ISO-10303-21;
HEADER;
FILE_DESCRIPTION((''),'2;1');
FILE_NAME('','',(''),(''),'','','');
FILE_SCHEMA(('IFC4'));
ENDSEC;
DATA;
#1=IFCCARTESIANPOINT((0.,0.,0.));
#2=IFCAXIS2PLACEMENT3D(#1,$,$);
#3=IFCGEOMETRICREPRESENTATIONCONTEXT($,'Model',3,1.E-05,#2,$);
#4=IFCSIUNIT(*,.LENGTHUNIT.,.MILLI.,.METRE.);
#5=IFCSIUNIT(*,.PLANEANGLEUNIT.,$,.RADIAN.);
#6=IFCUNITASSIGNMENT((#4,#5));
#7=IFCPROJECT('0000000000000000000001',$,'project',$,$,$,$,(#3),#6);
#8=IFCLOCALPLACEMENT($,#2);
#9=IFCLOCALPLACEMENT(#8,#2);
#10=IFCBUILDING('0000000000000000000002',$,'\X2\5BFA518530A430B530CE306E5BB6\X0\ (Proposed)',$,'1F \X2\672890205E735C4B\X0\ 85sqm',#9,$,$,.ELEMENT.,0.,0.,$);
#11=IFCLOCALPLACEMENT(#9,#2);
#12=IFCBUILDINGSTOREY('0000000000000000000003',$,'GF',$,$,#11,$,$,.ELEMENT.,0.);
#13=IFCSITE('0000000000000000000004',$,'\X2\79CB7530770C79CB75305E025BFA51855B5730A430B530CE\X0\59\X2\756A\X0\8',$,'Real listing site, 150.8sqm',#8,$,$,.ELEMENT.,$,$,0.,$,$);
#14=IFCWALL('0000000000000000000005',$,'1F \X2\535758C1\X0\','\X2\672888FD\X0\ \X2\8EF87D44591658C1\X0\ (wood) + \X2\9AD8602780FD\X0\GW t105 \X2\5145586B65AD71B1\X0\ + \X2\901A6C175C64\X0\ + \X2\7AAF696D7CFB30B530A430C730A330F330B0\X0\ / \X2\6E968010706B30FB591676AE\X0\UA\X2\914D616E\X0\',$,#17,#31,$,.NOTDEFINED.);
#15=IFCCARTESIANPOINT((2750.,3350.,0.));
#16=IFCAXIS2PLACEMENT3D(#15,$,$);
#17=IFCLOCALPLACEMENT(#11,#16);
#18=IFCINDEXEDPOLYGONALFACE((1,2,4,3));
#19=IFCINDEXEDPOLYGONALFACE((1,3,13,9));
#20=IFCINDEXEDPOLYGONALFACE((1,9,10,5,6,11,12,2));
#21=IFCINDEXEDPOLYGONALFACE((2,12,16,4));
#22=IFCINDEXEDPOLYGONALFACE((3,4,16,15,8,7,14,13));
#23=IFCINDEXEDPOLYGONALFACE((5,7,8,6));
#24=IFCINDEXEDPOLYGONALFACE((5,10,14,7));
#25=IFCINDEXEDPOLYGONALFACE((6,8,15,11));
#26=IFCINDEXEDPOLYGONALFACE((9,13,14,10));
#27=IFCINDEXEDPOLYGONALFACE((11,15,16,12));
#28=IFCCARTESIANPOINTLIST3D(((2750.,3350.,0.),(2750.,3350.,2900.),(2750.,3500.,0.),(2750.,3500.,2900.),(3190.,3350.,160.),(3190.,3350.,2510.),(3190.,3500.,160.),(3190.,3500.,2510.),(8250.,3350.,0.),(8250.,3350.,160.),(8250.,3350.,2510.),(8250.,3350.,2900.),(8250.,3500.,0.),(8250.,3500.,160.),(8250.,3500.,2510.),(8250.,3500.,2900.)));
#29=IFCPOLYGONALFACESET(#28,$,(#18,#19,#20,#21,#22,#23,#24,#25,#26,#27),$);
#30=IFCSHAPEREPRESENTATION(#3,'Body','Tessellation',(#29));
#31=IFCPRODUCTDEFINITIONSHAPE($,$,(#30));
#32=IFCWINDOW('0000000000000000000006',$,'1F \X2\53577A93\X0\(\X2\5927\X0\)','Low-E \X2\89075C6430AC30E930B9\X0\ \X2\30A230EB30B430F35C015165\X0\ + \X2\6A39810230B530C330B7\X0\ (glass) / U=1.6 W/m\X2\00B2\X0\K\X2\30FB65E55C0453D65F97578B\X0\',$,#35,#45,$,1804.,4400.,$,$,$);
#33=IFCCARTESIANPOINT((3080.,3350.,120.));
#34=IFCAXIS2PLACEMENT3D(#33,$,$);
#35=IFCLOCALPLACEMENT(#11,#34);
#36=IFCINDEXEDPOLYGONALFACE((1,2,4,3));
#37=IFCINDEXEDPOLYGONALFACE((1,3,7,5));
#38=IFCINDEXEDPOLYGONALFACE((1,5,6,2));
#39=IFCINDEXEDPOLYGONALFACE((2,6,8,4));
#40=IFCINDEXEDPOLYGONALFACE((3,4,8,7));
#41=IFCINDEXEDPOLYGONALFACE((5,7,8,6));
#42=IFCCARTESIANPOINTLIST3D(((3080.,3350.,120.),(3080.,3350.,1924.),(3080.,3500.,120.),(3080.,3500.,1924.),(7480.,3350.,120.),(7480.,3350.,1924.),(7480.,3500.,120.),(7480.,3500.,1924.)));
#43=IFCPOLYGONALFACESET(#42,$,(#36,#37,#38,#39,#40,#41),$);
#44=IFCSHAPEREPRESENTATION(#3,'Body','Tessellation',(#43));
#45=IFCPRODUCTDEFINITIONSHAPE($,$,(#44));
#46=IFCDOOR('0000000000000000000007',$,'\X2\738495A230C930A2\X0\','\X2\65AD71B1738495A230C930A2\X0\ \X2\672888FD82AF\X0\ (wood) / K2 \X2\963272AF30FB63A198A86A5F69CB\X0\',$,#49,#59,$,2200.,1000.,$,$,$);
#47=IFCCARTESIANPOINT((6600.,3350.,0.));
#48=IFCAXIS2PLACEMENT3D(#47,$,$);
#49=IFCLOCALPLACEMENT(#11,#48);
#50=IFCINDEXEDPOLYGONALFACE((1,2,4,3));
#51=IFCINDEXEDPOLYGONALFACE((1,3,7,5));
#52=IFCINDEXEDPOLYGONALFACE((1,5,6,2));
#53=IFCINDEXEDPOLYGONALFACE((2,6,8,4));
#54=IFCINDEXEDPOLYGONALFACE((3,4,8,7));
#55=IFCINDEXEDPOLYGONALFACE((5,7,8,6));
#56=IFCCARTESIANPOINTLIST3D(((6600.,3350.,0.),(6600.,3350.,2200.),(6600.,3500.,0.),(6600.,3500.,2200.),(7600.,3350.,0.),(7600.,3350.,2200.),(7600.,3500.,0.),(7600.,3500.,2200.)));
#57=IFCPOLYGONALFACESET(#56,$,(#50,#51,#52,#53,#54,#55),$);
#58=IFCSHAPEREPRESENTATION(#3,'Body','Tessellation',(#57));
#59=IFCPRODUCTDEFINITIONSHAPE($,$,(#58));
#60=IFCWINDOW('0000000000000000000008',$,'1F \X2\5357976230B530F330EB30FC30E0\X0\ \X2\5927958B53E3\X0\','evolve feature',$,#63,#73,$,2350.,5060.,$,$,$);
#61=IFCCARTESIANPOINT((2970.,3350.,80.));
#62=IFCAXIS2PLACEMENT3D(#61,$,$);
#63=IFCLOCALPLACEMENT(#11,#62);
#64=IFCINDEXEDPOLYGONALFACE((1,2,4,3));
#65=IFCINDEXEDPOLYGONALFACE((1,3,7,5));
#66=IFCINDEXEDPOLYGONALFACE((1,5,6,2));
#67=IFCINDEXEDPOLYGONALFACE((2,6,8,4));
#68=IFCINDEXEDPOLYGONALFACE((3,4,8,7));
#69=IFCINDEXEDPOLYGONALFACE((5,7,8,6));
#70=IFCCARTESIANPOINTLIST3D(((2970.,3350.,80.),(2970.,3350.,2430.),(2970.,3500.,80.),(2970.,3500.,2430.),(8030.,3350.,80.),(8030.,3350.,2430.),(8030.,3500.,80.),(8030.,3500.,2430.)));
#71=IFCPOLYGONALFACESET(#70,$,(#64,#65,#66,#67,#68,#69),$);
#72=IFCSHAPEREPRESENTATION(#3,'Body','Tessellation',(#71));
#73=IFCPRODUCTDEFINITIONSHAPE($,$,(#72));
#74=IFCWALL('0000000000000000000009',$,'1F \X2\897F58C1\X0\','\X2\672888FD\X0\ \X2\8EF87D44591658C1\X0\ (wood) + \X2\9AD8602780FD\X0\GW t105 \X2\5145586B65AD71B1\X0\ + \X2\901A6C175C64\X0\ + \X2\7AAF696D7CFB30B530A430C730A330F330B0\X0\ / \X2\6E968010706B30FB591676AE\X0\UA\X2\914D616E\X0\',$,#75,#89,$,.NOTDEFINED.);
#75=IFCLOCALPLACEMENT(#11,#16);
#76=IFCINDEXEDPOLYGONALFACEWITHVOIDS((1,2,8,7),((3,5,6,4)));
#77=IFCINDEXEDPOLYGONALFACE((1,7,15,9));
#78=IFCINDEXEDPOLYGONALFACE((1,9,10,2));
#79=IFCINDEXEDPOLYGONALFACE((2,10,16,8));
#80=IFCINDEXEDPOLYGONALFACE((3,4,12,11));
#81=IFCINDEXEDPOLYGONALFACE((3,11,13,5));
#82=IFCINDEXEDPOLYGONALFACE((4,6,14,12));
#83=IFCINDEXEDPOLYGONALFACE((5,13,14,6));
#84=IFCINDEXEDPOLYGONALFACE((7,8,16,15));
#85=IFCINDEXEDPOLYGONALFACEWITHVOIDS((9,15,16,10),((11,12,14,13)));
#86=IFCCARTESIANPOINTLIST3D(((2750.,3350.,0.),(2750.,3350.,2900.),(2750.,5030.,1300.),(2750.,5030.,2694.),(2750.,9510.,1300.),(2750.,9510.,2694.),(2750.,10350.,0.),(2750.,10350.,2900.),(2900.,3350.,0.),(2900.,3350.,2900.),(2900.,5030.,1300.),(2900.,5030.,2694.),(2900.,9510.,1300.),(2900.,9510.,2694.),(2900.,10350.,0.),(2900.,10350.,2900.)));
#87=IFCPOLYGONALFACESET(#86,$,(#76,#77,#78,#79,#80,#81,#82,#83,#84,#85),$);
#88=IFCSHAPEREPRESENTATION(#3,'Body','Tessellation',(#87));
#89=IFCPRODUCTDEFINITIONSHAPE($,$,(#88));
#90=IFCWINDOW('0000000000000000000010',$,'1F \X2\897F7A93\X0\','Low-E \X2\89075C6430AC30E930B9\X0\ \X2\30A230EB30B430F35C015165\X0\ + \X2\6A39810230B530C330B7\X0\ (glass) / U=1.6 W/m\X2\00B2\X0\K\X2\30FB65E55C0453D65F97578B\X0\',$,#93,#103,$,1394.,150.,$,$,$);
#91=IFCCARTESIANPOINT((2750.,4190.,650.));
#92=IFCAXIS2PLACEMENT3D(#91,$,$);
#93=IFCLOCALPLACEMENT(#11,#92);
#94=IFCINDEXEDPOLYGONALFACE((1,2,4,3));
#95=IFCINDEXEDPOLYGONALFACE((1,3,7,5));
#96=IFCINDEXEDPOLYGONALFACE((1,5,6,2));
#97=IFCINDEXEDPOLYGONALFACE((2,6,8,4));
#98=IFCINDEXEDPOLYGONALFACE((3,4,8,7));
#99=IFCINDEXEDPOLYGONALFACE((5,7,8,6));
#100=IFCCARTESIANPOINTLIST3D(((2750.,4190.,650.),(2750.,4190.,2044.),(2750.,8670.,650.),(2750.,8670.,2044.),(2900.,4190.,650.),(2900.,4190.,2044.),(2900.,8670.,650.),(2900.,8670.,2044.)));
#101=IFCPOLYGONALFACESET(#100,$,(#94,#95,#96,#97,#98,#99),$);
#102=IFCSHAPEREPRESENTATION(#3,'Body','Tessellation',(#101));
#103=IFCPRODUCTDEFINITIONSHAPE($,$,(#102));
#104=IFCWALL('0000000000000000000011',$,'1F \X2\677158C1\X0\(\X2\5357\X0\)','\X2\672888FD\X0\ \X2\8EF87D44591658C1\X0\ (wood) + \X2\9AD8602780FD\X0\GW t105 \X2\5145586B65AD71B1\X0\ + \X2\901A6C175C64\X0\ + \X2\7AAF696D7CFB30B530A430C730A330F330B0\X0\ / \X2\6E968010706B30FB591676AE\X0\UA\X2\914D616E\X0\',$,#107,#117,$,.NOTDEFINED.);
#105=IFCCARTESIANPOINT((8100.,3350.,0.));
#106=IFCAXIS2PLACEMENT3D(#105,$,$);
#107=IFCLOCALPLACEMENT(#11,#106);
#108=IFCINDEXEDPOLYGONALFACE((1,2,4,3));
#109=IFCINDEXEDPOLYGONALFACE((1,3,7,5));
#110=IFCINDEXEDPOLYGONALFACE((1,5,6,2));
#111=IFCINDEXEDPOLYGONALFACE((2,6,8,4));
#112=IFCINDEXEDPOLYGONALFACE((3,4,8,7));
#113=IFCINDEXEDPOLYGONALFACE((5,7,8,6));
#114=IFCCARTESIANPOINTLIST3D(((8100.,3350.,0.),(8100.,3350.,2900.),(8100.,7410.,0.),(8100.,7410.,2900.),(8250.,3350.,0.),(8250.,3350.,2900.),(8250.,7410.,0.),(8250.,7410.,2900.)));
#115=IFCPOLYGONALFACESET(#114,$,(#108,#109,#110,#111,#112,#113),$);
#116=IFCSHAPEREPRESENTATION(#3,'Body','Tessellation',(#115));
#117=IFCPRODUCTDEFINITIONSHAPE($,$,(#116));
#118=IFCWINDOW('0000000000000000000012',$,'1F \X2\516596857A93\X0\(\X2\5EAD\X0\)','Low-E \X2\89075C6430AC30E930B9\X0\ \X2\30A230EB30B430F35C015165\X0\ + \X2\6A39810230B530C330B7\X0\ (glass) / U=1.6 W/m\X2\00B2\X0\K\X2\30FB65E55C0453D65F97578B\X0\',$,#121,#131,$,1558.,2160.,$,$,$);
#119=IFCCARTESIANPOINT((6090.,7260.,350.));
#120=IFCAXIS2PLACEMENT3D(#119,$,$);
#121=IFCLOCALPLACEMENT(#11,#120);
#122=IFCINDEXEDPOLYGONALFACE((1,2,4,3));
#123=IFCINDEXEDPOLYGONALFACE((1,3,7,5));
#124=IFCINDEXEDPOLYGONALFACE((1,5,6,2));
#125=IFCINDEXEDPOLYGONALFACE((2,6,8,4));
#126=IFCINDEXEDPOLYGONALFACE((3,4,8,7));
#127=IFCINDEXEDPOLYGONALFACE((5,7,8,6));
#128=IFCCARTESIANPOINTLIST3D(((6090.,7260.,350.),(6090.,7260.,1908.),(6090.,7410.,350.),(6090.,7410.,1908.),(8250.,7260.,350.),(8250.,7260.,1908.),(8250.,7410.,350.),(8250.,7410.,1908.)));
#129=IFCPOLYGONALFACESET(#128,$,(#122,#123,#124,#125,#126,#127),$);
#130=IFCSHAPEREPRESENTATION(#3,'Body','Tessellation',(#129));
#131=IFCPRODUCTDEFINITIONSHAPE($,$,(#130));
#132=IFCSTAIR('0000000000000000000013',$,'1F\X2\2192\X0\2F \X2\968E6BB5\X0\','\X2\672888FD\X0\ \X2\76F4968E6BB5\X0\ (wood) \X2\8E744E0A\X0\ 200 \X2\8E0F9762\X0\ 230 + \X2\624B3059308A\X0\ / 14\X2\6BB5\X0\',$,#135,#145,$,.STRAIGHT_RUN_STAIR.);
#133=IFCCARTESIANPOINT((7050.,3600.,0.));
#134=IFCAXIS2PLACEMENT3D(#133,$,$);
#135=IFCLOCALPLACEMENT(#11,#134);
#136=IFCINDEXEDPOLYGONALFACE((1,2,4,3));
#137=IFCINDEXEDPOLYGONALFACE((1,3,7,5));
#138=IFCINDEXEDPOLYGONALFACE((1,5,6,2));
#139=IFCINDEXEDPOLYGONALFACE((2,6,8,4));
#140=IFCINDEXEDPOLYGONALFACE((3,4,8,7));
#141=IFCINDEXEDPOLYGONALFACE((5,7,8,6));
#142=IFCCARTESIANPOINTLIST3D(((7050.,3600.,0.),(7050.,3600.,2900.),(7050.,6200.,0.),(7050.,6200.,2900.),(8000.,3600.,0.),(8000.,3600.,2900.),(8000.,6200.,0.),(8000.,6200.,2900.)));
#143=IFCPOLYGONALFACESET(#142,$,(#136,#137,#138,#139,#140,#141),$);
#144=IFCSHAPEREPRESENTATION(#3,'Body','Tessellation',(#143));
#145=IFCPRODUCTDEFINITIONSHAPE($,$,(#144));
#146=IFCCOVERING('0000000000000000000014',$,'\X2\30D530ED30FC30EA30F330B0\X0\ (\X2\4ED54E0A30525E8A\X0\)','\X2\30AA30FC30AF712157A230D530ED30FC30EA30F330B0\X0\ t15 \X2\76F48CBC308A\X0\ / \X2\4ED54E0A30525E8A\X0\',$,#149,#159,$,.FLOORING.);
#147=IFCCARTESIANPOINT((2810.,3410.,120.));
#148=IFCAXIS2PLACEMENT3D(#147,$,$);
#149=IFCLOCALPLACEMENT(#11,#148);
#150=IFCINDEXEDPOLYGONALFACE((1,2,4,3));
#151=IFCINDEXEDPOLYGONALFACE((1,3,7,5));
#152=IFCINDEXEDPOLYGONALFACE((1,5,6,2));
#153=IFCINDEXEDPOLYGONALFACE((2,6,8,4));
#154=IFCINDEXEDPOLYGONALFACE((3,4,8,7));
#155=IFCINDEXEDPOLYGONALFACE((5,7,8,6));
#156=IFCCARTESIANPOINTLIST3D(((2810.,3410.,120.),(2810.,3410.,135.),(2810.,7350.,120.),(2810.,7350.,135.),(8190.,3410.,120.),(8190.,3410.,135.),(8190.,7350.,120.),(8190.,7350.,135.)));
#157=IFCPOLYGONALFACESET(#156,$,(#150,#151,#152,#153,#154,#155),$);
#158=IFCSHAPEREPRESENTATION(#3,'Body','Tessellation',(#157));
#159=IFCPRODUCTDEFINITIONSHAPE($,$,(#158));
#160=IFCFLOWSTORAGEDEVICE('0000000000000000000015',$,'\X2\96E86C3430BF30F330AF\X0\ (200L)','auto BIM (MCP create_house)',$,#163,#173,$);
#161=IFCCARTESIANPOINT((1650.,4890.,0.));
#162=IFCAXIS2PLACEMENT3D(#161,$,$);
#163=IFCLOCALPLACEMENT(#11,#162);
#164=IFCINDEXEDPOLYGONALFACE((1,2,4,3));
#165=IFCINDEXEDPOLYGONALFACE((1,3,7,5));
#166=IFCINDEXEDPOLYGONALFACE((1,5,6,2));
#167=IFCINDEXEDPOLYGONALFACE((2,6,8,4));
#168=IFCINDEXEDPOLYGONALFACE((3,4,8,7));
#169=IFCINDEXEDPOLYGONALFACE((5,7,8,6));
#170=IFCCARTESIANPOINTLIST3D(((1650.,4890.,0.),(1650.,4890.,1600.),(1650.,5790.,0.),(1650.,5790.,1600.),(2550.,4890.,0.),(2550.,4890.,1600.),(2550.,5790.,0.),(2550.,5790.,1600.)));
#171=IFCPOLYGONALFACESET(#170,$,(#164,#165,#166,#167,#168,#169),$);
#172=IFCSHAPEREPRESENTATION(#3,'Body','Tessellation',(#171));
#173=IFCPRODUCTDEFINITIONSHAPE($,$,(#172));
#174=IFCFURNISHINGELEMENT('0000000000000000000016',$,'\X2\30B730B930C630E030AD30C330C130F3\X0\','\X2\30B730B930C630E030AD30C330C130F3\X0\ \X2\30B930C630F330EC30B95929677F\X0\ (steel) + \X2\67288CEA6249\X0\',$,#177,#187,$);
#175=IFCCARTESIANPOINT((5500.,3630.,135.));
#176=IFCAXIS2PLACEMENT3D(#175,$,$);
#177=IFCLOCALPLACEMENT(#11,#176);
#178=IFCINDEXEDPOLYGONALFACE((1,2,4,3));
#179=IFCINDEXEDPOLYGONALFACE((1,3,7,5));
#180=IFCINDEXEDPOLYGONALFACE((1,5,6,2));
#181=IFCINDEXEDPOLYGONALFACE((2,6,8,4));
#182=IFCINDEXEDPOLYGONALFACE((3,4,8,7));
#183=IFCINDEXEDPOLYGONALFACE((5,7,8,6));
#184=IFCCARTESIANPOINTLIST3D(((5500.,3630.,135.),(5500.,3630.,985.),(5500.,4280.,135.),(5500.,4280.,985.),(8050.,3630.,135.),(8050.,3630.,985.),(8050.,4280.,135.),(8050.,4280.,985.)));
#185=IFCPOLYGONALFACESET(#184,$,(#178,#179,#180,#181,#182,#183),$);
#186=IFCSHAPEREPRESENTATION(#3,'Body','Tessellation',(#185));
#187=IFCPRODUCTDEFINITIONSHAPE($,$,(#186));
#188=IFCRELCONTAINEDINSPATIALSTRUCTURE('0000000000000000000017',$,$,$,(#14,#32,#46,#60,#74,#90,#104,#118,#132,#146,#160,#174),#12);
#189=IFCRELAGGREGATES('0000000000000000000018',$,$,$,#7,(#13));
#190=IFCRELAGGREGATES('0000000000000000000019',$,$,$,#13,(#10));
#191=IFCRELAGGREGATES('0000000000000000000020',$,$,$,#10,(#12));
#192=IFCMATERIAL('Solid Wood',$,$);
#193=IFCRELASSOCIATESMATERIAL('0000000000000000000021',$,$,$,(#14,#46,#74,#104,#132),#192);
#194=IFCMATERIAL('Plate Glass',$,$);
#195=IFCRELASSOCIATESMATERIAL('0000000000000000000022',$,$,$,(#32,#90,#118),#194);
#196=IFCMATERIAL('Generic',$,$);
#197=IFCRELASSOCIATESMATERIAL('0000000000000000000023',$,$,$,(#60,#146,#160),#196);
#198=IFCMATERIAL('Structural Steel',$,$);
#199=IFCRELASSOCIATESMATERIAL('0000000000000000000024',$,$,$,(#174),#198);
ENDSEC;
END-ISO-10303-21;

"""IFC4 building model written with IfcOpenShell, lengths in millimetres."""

from ifc_helpers import new_model, si_unit, frame, frame_2d, origin, place, context, project, spatial, rectangle, extrude, material, element, fill, save


model = new_model("IFC4")

# Units and contexts
model_context = context("Model", 3, precision=1e-05, world=origin())
ifc_project = project(units=[si_unit("LENGTHUNIT", "METRE", prefix="MILLI"), si_unit("PLANEANGLEUNIT", "RADIAN")], contexts=[model_context])

# Site, building, storey
site_placement = place(None, origin())
site = spatial("IfcSite", under=ifc_project, at=site_placement, Name="秋田県秋田市寺内字イサノ59番8", ObjectType="Real listing site, 150.8sqm", CompositionType="ELEMENT", RefElevation=0.0)
building_placement = place(site_placement, origin())
building = spatial("IfcBuilding", under=site, at=building_placement, Name="寺内イサノの家 (Proposed)", ObjectType="1F 木造平屋 85sqm", CompositionType="ELEMENT", ElevationOfRefHeight=0.0, ElevationOfTerrain=0.0)
storey_placement = place(building_placement, origin())
storey = spatial("IfcBuildingStorey", under=building, at=storey_placement, Name="GF", CompositionType="ELEMENT", Elevation=0.0)

# Shared definitions
ifc_material_1 = material(Name="Solid Wood")
ifc_material_2 = material(Name="Generic")

# Wall, openings, windows, door
wall_1_placement = place(storey_placement, frame((2750.0, 3350.0, 0.0)))
wall_1 = element("IfcWall", 1, at=wall_1_placement, inside=storey, material=ifc_material_1, Name="1F 南壁", Description="木製 軸組外壁 (wood) + 高性能GW t105 充填断熱 + 通気層 + 窯業系サイディング / 準耐火・外皮UA配慮", PredefinedType="NOTDEFINED", context=model_context, shape_type="SweptSolid", body=[
    extrude(rectangle(XDim=5500.0, YDim=150.0, at=frame_2d((2750.0, 75.0))), frame((2750.0, 3350.0, 0.0)), (0.0, 0.0, 1.0), 2900.0),
])
opening_1_placement = place(storey_placement, frame((3080.0, 3350.0, 120.0)))
opening_1 = element("IfcOpeningElement", 2, at=opening_1_placement, cuts=wall_1, PredefinedType="NOTDEFINED", context=model_context, shape_type="SweptSolid", body=[
    extrude(rectangle(XDim=4400.0, YDim=150.0, at=frame_2d((2200.0, 75.0))), frame((3080.0, 3350.0, 120.0)), (0.0, 0.0, 1.0), 1804.0),
])
opening_2_placement = place(storey_placement, frame((6600.0, 3350.0, 0.0)))
opening_2 = element("IfcOpeningElement", 3, at=opening_2_placement, cuts=wall_1, PredefinedType="NOTDEFINED", context=model_context, shape_type="SweptSolid", body=[
    extrude(rectangle(XDim=1000.0, YDim=150.0, at=frame_2d((500.0, 75.0))), frame((6600.0, 3350.0, 0.0)), (0.0, 0.0, 1.0), 2200.0),
])
opening_3_placement = place(storey_placement, frame((2970.0, 3350.0, 80.0)))
opening_3 = element("IfcOpeningElement", 4, at=opening_3_placement, cuts=wall_1, PredefinedType="NOTDEFINED", context=model_context, shape_type="SweptSolid", body=[
    extrude(rectangle(XDim=5060.0, YDim=150.0, at=frame_2d((2530.0, 75.0))), frame((2970.0, 3350.0, 80.0)), (0.0, 0.0, 1.0), 2350.0),
])
ifc_material_3 = material(Name="Plate Glass")
window_1_placement = place(storey_placement, frame((3080.0, 3350.0, 120.0)))
window_1 = element("IfcWindow", 5, at=window_1_placement, inside=storey, material=ifc_material_3, Name="1F 南窓(大)", Description="Low-E 複層ガラス アルゴン封入 + 樹脂サッシ (glass) / U=1.6 W/m²K・日射取得型", OverallHeight=1804.0, OverallWidth=4400.0, context=model_context, shape_type="SweptSolid", body=[
    extrude(rectangle(XDim=4400.0, YDim=150.0, at=frame_2d((2200.0, 75.0))), frame((3080.0, 3350.0, 120.0)), (0.0, 0.0, 1.0), 1804.0),
])
fill(opening_1, window_1)
door_1_placement = place(storey_placement, frame((6600.0, 3350.0, 0.0)))
door_1 = element("IfcDoor", 6, at=door_1_placement, inside=storey, material=ifc_material_1, Name="玄関ドア", Description="断熱玄関ドア 木製芯 (wood) / K2 防犯・採風機構", OverallHeight=2200.0, OverallWidth=1000.0, context=model_context, shape_type="SweptSolid", body=[
    extrude(rectangle(XDim=1000.0, YDim=150.0, at=frame_2d((500.0, 75.0))), frame((6600.0, 3350.0, 0.0)), (0.0, 0.0, 1.0), 2200.0),
])
fill(opening_2, door_1)
window_2_placement = place(storey_placement, frame((2970.0, 3350.0, 80.0)))
window_2 = element("IfcWindow", 7, at=window_2_placement, inside=storey, material=ifc_material_2, Name="1F 南面サンルーム 大開口", Description="evolve feature", OverallHeight=2350.0, OverallWidth=5060.0, context=model_context, shape_type="SweptSolid", body=[
    extrude(rectangle(XDim=5060.0, YDim=150.0, at=frame_2d((2530.0, 75.0))), frame((2970.0, 3350.0, 80.0)), (0.0, 0.0, 1.0), 2350.0),
])
fill(opening_3, window_2)

# Walls, openings, windows
wall_2_placement = place(storey_placement, frame((2750.0, 3350.0, 0.0)))
wall_2 = element("IfcWall", 8, at=wall_2_placement, inside=storey, material=ifc_material_1, Name="1F 西壁", Description="木製 軸組外壁 (wood) + 高性能GW t105 充填断熱 + 通気層 + 窯業系サイディング / 準耐火・外皮UA配慮", PredefinedType="NOTDEFINED", context=model_context, shape_type="SweptSolid", body=[
    extrude(rectangle(XDim=150.0, YDim=7000.0, at=frame_2d((75.0, 3500.0))), frame((2750.0, 3350.0, 0.0)), (0.0, 0.0, 1.0), 2900.0),
])
opening_4_placement = place(storey_placement, frame((2750.0, 4190.0, 650.0)))
opening_4 = element("IfcOpeningElement", 9, at=opening_4_placement, cuts=wall_2, PredefinedType="NOTDEFINED", context=model_context, shape_type="SweptSolid", body=[
    extrude(rectangle(XDim=150.0, YDim=4480.0, at=frame_2d((75.0, 2240.0))), frame((2750.0, 4190.0, 650.0)), (0.0, 0.0, 1.0), 1394.0),
])
window_3_placement = place(storey_placement, frame((2750.0, 4190.0, 650.0)))
window_3 = element("IfcWindow", 10, at=window_3_placement, inside=storey, material=ifc_material_3, Name="1F 西窓", Description="Low-E 複層ガラス アルゴン封入 + 樹脂サッシ (glass) / U=1.6 W/m²K・日射取得型", OverallHeight=1394.0, OverallWidth=150.0, context=model_context, shape_type="SweptSolid", body=[
    extrude(rectangle(XDim=150.0, YDim=4480.0, at=frame_2d((75.0, 2240.0))), frame((2750.0, 4190.0, 650.0)), (0.0, 0.0, 1.0), 1394.0),
])
fill(opening_4, window_3)
wall_3_placement = place(storey_placement, frame((8100.0, 3350.0, 0.0)))
wall_3 = element("IfcWall", 11, at=wall_3_placement, inside=storey, material=ifc_material_1, Name="1F 東壁(南)", Description="木製 軸組外壁 (wood) + 高性能GW t105 充填断熱 + 通気層 + 窯業系サイディング / 準耐火・外皮UA配慮", PredefinedType="NOTDEFINED", context=model_context, shape_type="SweptSolid", body=[
    extrude(rectangle(XDim=150.0, YDim=4060.0, at=frame_2d((75.0, 2030.0))), frame((8100.0, 3350.0, 0.0)), (0.0, 0.0, 1.0), 2900.0),
])
opening_5_placement = place(storey_placement, frame((6090.0, 7260.0, 350.0)))
opening_5 = element("IfcOpeningElement", 12, at=opening_5_placement, cuts=wall_3, PredefinedType="NOTDEFINED", context=model_context, shape_type="SweptSolid", body=[
    extrude(rectangle(XDim=2160.0, YDim=150.0, at=frame_2d((1080.0, 75.0))), frame((6090.0, 7260.0, 350.0)), (0.0, 0.0, 1.0), 1558.0),
])
window_4_placement = place(storey_placement, frame((6090.0, 7260.0, 350.0)))
window_4 = element("IfcWindow", 13, at=window_4_placement, inside=storey, material=ifc_material_3, Name="1F 入隅窓(庭)", Description="Low-E 複層ガラス アルゴン封入 + 樹脂サッシ (glass) / U=1.6 W/m²K・日射取得型", OverallHeight=1558.0, OverallWidth=2160.0, context=model_context, shape_type="SweptSolid", body=[
    extrude(rectangle(XDim=2160.0, YDim=150.0, at=frame_2d((1080.0, 75.0))), frame((6090.0, 7260.0, 350.0)), (0.0, 0.0, 1.0), 1558.0),
])
fill(opening_5, window_4)

# Stair
stair_placement = place(storey_placement, frame((7050.0, 3600.0, 0.0)))
element("IfcStair", 14, at=stair_placement, inside=storey, material=ifc_material_1, Name="1F→2F 階段", Description="木製 直階段 (wood) 蹴上 200 踏面 230 + 手すり / 14段", PredefinedType="STRAIGHT_RUN_STAIR", context=model_context, shape_type="SweptSolid", body=[
    extrude(rectangle(XDim=950.0, YDim=2600.0, at=frame_2d((475.0, 1300.0))), frame((7050.0, 3600.0, 0.0)), (0.0, 0.0, 1.0), 2900.0),
])

# Covering
covering_placement = place(storey_placement, frame((2810.0, 3410.0, 120.0)))
element("IfcCovering", 15, at=covering_placement, inside=storey, material=ifc_material_2, Name="フローリング (仕上げ床)", Description="オーク無垢フローリング t15 直貼り / 仕上げ床", PredefinedType="FLOORING", context=model_context, shape_type="SweptSolid", body=[
    extrude(rectangle(XDim=5380.0, YDim=3940.0, at=frame_2d((2690.0, 1970.0))), frame((2810.0, 3410.0, 120.0)), (0.0, 0.0, 1.0), 15.0),
])

# Flow storage device
flow_storage_device_placement = place(storey_placement, frame((1650.0, 4890.0, 0.0)))
element("IfcFlowStorageDevice", 16, at=flow_storage_device_placement, inside=storey, material=ifc_material_2, Name="雨水タンク (200L)", Description="auto BIM (MCP create_house)", context=model_context, shape_type="SweptSolid", body=[
    extrude(rectangle(XDim=900.0, YDim=900.0, at=frame_2d((450.0, 450.0))), frame((1650.0, 4890.0, 0.0)), (0.0, 0.0, 1.0), 1600.0),
])

# Furnishing element
ifc_material_4 = material(Name="Structural Steel")
furnishing_placement = place(storey_placement, frame((5500.0, 3630.0, 135.0)))
element("IfcFurnishingElement", 17, at=furnishing_placement, inside=storey, material=ifc_material_4, Name="システムキッチン", Description="システムキッチン ステンレス天板 (steel) + 木質扉", context=model_context, shape_type="SweptSolid", body=[
    extrude(rectangle(XDim=2550.0, YDim=650.0, at=frame_2d((1275.0, 325.0))), frame((5500.0, 3630.0, 135.0)), (0.0, 0.0, 1.0), 850.0),
])

save(model, "model.ifc")
